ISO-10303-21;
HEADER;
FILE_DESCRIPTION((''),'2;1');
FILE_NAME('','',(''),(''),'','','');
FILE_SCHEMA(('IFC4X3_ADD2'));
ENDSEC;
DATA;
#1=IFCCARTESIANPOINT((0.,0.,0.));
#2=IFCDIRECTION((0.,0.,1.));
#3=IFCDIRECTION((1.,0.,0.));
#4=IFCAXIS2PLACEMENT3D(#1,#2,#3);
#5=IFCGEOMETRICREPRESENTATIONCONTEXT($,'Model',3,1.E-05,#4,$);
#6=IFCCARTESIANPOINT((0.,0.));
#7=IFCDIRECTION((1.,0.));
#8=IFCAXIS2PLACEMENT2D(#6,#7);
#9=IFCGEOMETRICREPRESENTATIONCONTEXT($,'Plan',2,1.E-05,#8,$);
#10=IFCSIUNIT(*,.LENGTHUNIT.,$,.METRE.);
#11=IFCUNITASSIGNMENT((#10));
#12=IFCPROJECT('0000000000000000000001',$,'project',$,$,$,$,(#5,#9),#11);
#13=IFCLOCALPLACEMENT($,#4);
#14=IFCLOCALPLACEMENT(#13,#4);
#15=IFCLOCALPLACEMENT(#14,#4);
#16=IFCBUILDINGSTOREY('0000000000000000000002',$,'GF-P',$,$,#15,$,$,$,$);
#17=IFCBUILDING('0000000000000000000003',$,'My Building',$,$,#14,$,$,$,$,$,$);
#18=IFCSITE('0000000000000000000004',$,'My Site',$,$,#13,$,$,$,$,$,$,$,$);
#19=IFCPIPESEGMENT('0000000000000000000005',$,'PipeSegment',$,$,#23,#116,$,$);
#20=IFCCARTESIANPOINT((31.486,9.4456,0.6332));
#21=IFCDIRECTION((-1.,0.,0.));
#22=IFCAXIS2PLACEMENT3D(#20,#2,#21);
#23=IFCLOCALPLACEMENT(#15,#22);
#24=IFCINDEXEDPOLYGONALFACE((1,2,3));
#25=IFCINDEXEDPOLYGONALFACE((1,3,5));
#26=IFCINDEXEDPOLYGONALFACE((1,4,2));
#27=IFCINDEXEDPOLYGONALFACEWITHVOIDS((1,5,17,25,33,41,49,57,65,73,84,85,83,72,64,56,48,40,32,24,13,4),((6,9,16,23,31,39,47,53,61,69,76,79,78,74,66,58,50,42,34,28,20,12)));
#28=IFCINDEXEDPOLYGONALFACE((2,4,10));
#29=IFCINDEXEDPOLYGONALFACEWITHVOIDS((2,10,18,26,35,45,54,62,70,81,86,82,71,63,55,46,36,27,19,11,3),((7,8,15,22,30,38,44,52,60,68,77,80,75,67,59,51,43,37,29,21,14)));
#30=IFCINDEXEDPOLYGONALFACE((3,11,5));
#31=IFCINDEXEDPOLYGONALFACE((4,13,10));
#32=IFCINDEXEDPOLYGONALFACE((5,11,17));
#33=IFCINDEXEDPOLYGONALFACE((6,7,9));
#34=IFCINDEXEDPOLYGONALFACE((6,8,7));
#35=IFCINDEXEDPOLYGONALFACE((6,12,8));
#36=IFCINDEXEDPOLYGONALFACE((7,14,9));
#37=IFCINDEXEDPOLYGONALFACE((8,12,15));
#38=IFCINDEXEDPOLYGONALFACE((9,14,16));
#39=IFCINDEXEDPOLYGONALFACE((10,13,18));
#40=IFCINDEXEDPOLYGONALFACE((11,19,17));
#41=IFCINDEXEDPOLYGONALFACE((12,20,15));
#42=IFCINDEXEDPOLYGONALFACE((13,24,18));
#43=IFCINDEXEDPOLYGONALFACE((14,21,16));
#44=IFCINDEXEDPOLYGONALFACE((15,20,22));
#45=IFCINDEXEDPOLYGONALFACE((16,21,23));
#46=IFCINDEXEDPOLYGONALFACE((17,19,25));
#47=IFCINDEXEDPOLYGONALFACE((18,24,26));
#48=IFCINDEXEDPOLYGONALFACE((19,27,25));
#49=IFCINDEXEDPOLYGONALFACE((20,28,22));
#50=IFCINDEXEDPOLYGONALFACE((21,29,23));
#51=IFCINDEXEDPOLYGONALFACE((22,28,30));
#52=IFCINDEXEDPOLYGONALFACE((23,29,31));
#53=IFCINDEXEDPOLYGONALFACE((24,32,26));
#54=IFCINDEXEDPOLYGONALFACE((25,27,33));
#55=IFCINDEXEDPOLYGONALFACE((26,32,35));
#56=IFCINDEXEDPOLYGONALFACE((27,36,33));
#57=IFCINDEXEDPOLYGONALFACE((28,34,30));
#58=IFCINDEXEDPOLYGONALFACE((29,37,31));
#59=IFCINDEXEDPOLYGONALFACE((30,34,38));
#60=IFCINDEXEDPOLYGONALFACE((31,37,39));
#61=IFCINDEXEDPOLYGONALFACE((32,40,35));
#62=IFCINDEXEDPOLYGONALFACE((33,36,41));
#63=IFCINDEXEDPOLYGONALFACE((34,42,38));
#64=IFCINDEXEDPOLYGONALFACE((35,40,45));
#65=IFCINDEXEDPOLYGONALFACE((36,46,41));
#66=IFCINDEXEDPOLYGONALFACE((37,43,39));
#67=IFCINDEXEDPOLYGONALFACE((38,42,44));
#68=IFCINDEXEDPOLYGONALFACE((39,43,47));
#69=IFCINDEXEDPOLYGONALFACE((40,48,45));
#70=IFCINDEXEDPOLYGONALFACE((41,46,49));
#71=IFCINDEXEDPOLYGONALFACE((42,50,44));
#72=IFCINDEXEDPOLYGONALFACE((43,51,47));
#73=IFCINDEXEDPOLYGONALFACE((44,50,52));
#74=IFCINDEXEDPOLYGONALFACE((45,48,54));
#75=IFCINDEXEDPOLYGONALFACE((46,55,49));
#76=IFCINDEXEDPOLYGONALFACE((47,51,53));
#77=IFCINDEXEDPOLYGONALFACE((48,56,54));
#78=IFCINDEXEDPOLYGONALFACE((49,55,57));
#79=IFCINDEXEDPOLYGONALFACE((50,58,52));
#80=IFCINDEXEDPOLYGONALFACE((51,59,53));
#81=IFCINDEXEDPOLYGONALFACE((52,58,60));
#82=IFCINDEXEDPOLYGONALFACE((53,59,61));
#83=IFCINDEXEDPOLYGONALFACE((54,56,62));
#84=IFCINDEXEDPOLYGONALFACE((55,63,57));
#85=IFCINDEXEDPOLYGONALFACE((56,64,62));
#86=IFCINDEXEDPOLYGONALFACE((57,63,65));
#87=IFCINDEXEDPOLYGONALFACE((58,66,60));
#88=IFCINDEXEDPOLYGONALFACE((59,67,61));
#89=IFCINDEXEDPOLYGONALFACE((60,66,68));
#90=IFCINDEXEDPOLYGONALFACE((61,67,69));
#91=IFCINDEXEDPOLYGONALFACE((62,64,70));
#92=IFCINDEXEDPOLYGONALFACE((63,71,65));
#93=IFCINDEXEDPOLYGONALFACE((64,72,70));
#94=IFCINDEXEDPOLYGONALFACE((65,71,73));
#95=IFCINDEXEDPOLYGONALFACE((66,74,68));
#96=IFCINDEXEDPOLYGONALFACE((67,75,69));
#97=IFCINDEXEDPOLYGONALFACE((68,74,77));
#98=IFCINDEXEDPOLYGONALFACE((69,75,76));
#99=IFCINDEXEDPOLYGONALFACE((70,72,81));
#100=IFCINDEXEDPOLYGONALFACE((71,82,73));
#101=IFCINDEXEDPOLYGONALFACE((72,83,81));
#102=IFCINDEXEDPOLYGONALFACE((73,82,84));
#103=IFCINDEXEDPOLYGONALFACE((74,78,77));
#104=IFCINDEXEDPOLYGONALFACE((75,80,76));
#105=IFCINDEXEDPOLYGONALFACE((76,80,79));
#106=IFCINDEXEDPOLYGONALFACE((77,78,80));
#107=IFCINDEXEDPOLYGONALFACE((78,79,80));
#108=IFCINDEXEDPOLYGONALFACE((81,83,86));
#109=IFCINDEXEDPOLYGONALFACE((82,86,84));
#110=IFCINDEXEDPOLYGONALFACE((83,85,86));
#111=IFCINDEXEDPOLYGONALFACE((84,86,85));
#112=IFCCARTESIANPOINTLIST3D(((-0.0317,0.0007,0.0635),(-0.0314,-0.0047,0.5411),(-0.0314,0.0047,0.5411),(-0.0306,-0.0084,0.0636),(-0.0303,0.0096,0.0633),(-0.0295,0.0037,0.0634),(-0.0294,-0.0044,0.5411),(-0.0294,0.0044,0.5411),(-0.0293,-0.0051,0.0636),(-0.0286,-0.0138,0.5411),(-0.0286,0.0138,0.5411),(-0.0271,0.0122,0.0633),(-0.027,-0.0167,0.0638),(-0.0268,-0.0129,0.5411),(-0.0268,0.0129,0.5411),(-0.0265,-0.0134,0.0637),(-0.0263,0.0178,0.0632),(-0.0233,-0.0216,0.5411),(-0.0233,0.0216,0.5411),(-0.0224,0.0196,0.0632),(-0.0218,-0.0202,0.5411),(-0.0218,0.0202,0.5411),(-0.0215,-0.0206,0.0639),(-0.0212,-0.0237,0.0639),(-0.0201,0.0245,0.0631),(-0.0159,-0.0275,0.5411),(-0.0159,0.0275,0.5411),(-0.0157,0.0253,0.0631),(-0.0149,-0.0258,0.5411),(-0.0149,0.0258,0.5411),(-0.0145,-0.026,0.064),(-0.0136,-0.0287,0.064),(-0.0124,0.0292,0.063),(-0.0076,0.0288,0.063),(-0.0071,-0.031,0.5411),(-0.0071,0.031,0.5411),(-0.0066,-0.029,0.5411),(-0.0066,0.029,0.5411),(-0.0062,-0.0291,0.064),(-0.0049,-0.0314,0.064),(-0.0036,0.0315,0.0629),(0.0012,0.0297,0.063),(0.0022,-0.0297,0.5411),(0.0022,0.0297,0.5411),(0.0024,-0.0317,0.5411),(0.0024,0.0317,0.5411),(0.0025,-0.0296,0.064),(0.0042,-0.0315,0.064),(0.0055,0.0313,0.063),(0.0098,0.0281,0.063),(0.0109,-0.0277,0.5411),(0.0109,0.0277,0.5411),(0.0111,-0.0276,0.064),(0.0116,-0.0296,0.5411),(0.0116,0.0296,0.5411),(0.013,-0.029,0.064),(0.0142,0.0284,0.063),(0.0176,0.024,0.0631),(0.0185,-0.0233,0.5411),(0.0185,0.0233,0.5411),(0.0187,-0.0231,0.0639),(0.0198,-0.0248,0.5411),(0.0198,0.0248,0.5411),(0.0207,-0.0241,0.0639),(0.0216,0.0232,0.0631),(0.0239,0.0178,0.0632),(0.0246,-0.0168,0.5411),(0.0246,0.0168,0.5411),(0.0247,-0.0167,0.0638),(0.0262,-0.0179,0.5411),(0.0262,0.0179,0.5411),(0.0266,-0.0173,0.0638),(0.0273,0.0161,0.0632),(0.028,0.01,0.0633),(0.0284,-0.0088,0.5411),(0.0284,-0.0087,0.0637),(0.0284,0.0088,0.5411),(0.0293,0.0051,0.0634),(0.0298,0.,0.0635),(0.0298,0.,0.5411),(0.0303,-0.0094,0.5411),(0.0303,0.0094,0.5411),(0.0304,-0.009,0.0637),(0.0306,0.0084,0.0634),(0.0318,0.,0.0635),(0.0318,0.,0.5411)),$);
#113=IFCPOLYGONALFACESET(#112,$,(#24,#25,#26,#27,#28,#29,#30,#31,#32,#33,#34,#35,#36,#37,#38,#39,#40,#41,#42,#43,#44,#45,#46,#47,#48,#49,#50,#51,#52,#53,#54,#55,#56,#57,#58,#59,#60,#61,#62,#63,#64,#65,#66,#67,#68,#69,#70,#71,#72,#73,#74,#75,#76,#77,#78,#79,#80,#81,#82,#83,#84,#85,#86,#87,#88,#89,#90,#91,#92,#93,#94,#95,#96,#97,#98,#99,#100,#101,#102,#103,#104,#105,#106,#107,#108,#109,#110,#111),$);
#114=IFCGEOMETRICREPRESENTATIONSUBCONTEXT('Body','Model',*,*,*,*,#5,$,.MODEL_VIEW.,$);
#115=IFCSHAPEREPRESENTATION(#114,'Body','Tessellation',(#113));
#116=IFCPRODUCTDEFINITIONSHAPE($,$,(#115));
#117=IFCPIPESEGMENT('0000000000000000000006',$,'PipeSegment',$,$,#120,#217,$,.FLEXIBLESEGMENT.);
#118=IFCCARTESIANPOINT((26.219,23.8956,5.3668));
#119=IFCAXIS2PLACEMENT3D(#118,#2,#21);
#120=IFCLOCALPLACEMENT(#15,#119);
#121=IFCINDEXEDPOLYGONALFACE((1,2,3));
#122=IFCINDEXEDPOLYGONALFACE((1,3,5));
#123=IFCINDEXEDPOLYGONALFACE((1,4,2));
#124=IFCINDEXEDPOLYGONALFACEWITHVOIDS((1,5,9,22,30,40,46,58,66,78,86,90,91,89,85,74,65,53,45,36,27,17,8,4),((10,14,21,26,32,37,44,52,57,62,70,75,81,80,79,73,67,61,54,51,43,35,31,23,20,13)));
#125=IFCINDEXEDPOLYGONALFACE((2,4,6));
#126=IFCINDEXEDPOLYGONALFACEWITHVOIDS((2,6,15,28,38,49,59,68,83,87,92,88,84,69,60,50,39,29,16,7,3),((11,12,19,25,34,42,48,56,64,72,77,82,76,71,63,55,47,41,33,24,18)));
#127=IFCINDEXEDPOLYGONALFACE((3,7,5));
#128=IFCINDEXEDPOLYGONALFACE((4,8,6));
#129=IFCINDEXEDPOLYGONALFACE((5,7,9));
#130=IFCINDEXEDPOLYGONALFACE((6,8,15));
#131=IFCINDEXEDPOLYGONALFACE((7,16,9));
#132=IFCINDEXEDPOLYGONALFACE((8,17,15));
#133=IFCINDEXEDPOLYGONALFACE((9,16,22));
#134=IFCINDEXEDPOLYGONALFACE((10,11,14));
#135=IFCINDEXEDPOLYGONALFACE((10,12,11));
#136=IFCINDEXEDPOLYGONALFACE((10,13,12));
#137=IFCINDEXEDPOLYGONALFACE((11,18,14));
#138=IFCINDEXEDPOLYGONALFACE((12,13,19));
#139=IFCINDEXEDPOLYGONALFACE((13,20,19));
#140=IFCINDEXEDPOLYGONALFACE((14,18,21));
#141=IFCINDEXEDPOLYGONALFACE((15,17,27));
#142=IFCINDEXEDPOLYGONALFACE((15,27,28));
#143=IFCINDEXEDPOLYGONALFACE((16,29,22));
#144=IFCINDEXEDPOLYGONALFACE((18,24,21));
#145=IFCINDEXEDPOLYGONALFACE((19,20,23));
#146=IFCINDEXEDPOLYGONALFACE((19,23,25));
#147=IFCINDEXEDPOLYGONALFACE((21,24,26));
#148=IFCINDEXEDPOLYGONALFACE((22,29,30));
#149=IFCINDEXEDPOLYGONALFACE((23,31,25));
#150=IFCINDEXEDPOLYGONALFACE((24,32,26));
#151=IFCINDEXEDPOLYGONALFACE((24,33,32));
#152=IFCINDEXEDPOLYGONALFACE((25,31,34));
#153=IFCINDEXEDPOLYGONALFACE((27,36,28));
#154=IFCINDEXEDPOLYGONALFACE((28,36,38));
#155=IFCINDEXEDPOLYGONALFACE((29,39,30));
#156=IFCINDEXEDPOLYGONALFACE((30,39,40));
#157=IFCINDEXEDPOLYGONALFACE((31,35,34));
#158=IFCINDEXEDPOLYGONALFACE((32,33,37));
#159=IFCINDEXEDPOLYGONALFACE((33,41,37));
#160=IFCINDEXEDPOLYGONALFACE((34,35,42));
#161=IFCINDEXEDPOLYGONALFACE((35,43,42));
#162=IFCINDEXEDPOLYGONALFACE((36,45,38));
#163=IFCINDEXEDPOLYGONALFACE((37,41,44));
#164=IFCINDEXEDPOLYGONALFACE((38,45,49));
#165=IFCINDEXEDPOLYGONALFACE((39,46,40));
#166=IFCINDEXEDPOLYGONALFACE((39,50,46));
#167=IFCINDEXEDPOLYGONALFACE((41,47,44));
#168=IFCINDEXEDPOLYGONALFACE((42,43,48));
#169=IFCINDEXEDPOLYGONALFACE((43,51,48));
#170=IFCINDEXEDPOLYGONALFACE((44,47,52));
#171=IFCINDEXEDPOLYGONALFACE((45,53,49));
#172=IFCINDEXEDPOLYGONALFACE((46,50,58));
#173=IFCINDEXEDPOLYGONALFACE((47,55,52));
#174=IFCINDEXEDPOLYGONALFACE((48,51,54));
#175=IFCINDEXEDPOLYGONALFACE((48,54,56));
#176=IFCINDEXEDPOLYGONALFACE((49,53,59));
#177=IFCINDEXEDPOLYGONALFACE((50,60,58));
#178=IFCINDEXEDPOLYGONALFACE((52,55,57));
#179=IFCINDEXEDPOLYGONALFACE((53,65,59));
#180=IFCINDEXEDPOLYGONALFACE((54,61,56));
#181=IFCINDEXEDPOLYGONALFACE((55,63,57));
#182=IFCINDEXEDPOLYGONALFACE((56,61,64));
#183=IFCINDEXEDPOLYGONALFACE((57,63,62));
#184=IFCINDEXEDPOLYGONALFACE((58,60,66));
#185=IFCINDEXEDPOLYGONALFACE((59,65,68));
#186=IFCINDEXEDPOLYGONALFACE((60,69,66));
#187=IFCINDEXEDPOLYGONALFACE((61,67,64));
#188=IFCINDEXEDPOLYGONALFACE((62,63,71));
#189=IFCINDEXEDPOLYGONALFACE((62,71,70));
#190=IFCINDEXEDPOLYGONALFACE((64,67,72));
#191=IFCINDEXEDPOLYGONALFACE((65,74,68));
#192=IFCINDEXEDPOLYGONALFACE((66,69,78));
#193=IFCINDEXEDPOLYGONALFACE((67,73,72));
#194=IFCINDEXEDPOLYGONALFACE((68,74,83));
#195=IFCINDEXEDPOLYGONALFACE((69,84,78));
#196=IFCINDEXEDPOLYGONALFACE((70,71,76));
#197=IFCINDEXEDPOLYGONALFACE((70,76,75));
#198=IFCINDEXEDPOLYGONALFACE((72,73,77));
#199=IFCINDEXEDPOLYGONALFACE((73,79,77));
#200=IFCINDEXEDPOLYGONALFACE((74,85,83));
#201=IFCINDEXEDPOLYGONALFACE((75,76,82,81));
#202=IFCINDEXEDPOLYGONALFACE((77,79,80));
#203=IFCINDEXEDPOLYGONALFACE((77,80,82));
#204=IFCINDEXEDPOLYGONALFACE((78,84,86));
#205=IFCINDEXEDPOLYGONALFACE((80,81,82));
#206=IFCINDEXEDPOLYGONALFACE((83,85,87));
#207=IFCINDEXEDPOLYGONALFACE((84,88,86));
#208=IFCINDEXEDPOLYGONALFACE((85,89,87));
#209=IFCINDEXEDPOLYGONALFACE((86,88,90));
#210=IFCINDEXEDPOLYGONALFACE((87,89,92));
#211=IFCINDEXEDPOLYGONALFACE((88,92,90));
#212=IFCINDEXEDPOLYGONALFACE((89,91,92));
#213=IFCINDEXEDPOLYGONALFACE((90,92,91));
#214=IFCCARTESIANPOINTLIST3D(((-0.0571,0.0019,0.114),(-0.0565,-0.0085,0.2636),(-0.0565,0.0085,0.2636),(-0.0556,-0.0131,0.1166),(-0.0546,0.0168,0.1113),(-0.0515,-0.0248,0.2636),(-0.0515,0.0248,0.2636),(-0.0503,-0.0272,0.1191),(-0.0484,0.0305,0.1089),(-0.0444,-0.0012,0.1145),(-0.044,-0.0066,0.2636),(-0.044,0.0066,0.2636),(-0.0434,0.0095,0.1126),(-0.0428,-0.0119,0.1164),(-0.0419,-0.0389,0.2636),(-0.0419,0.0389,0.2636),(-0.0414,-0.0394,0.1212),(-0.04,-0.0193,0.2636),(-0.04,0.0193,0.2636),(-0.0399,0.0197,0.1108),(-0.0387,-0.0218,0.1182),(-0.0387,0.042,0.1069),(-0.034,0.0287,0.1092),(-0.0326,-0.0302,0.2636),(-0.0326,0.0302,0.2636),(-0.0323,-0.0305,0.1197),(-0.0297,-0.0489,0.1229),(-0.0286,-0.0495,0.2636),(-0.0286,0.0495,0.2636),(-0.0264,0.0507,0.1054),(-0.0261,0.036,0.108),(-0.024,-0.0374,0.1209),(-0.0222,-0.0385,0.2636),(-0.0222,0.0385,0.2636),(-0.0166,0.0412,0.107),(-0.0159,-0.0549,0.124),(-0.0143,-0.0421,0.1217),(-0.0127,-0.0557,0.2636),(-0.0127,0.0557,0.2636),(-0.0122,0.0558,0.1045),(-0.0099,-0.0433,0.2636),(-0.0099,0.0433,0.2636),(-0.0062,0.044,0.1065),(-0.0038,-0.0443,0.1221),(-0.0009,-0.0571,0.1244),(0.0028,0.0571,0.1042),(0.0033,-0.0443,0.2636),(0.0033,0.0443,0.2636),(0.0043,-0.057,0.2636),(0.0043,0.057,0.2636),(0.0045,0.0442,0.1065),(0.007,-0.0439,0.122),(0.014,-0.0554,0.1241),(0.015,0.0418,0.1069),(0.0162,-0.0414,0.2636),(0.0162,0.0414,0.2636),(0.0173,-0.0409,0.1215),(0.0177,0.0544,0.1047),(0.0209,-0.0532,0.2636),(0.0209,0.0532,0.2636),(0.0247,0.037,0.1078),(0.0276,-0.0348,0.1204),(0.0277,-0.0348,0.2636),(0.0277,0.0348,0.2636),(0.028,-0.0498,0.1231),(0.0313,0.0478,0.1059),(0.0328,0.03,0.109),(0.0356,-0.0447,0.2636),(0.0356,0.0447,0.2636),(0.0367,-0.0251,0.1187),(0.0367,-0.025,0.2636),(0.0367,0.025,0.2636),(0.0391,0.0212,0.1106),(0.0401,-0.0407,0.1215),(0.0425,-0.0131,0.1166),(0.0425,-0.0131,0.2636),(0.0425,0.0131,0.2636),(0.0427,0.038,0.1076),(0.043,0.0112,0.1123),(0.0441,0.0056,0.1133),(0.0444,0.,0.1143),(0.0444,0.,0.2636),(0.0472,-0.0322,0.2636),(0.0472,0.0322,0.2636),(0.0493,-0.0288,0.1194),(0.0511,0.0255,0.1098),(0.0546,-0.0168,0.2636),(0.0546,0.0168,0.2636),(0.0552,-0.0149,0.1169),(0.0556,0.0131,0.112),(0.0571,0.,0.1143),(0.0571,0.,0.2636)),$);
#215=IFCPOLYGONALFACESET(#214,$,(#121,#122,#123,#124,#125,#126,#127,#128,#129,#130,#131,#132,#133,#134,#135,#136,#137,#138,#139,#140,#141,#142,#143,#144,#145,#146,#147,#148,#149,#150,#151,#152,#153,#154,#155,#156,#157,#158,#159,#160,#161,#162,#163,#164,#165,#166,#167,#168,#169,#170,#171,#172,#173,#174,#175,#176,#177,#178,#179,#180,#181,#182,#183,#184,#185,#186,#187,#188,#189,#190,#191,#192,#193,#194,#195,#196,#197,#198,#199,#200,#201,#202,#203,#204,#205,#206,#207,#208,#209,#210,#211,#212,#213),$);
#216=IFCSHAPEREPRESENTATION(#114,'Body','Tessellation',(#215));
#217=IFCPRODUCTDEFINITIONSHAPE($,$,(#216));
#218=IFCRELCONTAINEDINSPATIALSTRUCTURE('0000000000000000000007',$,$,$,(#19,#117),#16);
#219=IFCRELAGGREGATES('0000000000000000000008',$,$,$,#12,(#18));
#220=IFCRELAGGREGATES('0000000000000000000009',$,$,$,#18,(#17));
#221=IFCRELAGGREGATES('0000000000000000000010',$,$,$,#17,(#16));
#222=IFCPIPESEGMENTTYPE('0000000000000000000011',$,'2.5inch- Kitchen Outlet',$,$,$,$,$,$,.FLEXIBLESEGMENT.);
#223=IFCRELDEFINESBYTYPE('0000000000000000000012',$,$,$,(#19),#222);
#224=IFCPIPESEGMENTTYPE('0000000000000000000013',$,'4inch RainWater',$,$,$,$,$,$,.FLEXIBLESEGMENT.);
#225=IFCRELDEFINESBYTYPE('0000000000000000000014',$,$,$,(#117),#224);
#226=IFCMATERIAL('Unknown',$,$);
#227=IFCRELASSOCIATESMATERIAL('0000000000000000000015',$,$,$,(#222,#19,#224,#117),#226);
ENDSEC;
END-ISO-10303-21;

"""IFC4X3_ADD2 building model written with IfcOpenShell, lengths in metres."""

from ifc_helpers import new_model, si_unit, frame, origin_with_axes, origin_2d_with_axis, place, context, subcontext, project, spatial, hollow_circle, extrude, clip, halfspace, material, material_profile, profile_set, profile_usage, type_object, element, save


model = new_model("IFC4X3_ADD2")

# Units and contexts
model_context = context("Model", 3, precision=1e-05, world=origin_with_axes())
plan_context = context("Plan", 2, precision=1e-05, world=origin_2d_with_axis())
body_context = subcontext(model_context, "Body", "Model", "MODEL_VIEW")
ifc_project = project(units=[si_unit("LENGTHUNIT", "METRE")], contexts=[model_context, plan_context])

# Site, building, storey
site_placement = place(None, origin_with_axes())
site = spatial("IfcSite", under=ifc_project, at=site_placement, Name="My Site")
building_placement = place(site_placement, origin_with_axes())
building = spatial("IfcBuilding", under=site, at=building_placement, Name="My Building")
storey_placement = place(building_placement, origin_with_axes())
storey = spatial("IfcBuildingStorey", under=building, at=storey_placement, Name="GF-P")

# Pipe segments
ifc_material_1 = material(Name="Unknown")
ifc_material_profile_1 = material_profile(ifc_material_1, hollow_circle(Radius=0.0318, WallThickness=0.002))
ifc_profile_set_1 = profile_set([ifc_material_profile_1], Name="kitchenwater")
pipe_segment_type_1 = type_object("IfcPipeSegmentType", Name="2.5inch- Kitchen Outlet", PredefinedType="FLEXIBLESEGMENT", material=ifc_profile_set_1)
ifc_profile_usage_1 = profile_usage(ifc_profile_set_1)
pipe_segment_1_placement = place(storey_placement, frame((31.486, 9.4456, 0.6332), z_axis=(0.0, 0.0, 1.0), x_axis=(-1.0, 0.0, 0.0)))
element("IfcPipeSegment", 1, at=pipe_segment_1_placement, inside=storey, type_object=pipe_segment_type_1, material=ifc_profile_usage_1, Name="PipeSegment", context=body_context, shape_type="Clipping", body=[
    clip(extrude(hollow_circle(Radius=0.0318, WallThickness=0.002), origin_with_axes(), (0.0, 0.0, 1.0), 0.5411), halfspace(frame((0.0, -0.0323, 0.0641), z_axis=(0.0, -0.017452, -0.999848), x_axis=(-1.0, -0.000019, 0.0)), False)),
])
ifc_material_profile_2 = material_profile(ifc_material_1, hollow_circle(Radius=0.0571, WallThickness=0.0127))
ifc_profile_set_2 = profile_set([ifc_material_profile_2], Name="rainwater")
pipe_segment_type_2 = type_object("IfcPipeSegmentType", Name="4inch RainWater", PredefinedType="FLEXIBLESEGMENT", material=ifc_profile_set_2)
ifc_profile_usage_2 = profile_usage(ifc_profile_set_2)
pipe_segment_2_placement = place(storey_placement, frame((26.219, 23.8956, 5.3668), z_axis=(0.0, 0.0, 1.0), x_axis=(-1.0, 0.0, 0.0)))
element("IfcPipeSegment", 2, at=pipe_segment_2_placement, inside=storey, type_object=pipe_segment_type_2, material=ifc_profile_usage_2, Name="PipeSegment", PredefinedType="FLEXIBLESEGMENT", context=body_context, shape_type="Clipping", body=[
    clip(extrude(hollow_circle(Radius=0.0571, WallThickness=0.0127), origin_with_axes(), (0.0, 0.0, 1.0), 0.2636), halfspace(frame((0.0, 0.9841, -0.0592), z_axis=(0.0, -0.173648, -0.984808), x_axis=(-1.0, 0.0, 0.0)), False)),
])

save(model, "model.ifc")
